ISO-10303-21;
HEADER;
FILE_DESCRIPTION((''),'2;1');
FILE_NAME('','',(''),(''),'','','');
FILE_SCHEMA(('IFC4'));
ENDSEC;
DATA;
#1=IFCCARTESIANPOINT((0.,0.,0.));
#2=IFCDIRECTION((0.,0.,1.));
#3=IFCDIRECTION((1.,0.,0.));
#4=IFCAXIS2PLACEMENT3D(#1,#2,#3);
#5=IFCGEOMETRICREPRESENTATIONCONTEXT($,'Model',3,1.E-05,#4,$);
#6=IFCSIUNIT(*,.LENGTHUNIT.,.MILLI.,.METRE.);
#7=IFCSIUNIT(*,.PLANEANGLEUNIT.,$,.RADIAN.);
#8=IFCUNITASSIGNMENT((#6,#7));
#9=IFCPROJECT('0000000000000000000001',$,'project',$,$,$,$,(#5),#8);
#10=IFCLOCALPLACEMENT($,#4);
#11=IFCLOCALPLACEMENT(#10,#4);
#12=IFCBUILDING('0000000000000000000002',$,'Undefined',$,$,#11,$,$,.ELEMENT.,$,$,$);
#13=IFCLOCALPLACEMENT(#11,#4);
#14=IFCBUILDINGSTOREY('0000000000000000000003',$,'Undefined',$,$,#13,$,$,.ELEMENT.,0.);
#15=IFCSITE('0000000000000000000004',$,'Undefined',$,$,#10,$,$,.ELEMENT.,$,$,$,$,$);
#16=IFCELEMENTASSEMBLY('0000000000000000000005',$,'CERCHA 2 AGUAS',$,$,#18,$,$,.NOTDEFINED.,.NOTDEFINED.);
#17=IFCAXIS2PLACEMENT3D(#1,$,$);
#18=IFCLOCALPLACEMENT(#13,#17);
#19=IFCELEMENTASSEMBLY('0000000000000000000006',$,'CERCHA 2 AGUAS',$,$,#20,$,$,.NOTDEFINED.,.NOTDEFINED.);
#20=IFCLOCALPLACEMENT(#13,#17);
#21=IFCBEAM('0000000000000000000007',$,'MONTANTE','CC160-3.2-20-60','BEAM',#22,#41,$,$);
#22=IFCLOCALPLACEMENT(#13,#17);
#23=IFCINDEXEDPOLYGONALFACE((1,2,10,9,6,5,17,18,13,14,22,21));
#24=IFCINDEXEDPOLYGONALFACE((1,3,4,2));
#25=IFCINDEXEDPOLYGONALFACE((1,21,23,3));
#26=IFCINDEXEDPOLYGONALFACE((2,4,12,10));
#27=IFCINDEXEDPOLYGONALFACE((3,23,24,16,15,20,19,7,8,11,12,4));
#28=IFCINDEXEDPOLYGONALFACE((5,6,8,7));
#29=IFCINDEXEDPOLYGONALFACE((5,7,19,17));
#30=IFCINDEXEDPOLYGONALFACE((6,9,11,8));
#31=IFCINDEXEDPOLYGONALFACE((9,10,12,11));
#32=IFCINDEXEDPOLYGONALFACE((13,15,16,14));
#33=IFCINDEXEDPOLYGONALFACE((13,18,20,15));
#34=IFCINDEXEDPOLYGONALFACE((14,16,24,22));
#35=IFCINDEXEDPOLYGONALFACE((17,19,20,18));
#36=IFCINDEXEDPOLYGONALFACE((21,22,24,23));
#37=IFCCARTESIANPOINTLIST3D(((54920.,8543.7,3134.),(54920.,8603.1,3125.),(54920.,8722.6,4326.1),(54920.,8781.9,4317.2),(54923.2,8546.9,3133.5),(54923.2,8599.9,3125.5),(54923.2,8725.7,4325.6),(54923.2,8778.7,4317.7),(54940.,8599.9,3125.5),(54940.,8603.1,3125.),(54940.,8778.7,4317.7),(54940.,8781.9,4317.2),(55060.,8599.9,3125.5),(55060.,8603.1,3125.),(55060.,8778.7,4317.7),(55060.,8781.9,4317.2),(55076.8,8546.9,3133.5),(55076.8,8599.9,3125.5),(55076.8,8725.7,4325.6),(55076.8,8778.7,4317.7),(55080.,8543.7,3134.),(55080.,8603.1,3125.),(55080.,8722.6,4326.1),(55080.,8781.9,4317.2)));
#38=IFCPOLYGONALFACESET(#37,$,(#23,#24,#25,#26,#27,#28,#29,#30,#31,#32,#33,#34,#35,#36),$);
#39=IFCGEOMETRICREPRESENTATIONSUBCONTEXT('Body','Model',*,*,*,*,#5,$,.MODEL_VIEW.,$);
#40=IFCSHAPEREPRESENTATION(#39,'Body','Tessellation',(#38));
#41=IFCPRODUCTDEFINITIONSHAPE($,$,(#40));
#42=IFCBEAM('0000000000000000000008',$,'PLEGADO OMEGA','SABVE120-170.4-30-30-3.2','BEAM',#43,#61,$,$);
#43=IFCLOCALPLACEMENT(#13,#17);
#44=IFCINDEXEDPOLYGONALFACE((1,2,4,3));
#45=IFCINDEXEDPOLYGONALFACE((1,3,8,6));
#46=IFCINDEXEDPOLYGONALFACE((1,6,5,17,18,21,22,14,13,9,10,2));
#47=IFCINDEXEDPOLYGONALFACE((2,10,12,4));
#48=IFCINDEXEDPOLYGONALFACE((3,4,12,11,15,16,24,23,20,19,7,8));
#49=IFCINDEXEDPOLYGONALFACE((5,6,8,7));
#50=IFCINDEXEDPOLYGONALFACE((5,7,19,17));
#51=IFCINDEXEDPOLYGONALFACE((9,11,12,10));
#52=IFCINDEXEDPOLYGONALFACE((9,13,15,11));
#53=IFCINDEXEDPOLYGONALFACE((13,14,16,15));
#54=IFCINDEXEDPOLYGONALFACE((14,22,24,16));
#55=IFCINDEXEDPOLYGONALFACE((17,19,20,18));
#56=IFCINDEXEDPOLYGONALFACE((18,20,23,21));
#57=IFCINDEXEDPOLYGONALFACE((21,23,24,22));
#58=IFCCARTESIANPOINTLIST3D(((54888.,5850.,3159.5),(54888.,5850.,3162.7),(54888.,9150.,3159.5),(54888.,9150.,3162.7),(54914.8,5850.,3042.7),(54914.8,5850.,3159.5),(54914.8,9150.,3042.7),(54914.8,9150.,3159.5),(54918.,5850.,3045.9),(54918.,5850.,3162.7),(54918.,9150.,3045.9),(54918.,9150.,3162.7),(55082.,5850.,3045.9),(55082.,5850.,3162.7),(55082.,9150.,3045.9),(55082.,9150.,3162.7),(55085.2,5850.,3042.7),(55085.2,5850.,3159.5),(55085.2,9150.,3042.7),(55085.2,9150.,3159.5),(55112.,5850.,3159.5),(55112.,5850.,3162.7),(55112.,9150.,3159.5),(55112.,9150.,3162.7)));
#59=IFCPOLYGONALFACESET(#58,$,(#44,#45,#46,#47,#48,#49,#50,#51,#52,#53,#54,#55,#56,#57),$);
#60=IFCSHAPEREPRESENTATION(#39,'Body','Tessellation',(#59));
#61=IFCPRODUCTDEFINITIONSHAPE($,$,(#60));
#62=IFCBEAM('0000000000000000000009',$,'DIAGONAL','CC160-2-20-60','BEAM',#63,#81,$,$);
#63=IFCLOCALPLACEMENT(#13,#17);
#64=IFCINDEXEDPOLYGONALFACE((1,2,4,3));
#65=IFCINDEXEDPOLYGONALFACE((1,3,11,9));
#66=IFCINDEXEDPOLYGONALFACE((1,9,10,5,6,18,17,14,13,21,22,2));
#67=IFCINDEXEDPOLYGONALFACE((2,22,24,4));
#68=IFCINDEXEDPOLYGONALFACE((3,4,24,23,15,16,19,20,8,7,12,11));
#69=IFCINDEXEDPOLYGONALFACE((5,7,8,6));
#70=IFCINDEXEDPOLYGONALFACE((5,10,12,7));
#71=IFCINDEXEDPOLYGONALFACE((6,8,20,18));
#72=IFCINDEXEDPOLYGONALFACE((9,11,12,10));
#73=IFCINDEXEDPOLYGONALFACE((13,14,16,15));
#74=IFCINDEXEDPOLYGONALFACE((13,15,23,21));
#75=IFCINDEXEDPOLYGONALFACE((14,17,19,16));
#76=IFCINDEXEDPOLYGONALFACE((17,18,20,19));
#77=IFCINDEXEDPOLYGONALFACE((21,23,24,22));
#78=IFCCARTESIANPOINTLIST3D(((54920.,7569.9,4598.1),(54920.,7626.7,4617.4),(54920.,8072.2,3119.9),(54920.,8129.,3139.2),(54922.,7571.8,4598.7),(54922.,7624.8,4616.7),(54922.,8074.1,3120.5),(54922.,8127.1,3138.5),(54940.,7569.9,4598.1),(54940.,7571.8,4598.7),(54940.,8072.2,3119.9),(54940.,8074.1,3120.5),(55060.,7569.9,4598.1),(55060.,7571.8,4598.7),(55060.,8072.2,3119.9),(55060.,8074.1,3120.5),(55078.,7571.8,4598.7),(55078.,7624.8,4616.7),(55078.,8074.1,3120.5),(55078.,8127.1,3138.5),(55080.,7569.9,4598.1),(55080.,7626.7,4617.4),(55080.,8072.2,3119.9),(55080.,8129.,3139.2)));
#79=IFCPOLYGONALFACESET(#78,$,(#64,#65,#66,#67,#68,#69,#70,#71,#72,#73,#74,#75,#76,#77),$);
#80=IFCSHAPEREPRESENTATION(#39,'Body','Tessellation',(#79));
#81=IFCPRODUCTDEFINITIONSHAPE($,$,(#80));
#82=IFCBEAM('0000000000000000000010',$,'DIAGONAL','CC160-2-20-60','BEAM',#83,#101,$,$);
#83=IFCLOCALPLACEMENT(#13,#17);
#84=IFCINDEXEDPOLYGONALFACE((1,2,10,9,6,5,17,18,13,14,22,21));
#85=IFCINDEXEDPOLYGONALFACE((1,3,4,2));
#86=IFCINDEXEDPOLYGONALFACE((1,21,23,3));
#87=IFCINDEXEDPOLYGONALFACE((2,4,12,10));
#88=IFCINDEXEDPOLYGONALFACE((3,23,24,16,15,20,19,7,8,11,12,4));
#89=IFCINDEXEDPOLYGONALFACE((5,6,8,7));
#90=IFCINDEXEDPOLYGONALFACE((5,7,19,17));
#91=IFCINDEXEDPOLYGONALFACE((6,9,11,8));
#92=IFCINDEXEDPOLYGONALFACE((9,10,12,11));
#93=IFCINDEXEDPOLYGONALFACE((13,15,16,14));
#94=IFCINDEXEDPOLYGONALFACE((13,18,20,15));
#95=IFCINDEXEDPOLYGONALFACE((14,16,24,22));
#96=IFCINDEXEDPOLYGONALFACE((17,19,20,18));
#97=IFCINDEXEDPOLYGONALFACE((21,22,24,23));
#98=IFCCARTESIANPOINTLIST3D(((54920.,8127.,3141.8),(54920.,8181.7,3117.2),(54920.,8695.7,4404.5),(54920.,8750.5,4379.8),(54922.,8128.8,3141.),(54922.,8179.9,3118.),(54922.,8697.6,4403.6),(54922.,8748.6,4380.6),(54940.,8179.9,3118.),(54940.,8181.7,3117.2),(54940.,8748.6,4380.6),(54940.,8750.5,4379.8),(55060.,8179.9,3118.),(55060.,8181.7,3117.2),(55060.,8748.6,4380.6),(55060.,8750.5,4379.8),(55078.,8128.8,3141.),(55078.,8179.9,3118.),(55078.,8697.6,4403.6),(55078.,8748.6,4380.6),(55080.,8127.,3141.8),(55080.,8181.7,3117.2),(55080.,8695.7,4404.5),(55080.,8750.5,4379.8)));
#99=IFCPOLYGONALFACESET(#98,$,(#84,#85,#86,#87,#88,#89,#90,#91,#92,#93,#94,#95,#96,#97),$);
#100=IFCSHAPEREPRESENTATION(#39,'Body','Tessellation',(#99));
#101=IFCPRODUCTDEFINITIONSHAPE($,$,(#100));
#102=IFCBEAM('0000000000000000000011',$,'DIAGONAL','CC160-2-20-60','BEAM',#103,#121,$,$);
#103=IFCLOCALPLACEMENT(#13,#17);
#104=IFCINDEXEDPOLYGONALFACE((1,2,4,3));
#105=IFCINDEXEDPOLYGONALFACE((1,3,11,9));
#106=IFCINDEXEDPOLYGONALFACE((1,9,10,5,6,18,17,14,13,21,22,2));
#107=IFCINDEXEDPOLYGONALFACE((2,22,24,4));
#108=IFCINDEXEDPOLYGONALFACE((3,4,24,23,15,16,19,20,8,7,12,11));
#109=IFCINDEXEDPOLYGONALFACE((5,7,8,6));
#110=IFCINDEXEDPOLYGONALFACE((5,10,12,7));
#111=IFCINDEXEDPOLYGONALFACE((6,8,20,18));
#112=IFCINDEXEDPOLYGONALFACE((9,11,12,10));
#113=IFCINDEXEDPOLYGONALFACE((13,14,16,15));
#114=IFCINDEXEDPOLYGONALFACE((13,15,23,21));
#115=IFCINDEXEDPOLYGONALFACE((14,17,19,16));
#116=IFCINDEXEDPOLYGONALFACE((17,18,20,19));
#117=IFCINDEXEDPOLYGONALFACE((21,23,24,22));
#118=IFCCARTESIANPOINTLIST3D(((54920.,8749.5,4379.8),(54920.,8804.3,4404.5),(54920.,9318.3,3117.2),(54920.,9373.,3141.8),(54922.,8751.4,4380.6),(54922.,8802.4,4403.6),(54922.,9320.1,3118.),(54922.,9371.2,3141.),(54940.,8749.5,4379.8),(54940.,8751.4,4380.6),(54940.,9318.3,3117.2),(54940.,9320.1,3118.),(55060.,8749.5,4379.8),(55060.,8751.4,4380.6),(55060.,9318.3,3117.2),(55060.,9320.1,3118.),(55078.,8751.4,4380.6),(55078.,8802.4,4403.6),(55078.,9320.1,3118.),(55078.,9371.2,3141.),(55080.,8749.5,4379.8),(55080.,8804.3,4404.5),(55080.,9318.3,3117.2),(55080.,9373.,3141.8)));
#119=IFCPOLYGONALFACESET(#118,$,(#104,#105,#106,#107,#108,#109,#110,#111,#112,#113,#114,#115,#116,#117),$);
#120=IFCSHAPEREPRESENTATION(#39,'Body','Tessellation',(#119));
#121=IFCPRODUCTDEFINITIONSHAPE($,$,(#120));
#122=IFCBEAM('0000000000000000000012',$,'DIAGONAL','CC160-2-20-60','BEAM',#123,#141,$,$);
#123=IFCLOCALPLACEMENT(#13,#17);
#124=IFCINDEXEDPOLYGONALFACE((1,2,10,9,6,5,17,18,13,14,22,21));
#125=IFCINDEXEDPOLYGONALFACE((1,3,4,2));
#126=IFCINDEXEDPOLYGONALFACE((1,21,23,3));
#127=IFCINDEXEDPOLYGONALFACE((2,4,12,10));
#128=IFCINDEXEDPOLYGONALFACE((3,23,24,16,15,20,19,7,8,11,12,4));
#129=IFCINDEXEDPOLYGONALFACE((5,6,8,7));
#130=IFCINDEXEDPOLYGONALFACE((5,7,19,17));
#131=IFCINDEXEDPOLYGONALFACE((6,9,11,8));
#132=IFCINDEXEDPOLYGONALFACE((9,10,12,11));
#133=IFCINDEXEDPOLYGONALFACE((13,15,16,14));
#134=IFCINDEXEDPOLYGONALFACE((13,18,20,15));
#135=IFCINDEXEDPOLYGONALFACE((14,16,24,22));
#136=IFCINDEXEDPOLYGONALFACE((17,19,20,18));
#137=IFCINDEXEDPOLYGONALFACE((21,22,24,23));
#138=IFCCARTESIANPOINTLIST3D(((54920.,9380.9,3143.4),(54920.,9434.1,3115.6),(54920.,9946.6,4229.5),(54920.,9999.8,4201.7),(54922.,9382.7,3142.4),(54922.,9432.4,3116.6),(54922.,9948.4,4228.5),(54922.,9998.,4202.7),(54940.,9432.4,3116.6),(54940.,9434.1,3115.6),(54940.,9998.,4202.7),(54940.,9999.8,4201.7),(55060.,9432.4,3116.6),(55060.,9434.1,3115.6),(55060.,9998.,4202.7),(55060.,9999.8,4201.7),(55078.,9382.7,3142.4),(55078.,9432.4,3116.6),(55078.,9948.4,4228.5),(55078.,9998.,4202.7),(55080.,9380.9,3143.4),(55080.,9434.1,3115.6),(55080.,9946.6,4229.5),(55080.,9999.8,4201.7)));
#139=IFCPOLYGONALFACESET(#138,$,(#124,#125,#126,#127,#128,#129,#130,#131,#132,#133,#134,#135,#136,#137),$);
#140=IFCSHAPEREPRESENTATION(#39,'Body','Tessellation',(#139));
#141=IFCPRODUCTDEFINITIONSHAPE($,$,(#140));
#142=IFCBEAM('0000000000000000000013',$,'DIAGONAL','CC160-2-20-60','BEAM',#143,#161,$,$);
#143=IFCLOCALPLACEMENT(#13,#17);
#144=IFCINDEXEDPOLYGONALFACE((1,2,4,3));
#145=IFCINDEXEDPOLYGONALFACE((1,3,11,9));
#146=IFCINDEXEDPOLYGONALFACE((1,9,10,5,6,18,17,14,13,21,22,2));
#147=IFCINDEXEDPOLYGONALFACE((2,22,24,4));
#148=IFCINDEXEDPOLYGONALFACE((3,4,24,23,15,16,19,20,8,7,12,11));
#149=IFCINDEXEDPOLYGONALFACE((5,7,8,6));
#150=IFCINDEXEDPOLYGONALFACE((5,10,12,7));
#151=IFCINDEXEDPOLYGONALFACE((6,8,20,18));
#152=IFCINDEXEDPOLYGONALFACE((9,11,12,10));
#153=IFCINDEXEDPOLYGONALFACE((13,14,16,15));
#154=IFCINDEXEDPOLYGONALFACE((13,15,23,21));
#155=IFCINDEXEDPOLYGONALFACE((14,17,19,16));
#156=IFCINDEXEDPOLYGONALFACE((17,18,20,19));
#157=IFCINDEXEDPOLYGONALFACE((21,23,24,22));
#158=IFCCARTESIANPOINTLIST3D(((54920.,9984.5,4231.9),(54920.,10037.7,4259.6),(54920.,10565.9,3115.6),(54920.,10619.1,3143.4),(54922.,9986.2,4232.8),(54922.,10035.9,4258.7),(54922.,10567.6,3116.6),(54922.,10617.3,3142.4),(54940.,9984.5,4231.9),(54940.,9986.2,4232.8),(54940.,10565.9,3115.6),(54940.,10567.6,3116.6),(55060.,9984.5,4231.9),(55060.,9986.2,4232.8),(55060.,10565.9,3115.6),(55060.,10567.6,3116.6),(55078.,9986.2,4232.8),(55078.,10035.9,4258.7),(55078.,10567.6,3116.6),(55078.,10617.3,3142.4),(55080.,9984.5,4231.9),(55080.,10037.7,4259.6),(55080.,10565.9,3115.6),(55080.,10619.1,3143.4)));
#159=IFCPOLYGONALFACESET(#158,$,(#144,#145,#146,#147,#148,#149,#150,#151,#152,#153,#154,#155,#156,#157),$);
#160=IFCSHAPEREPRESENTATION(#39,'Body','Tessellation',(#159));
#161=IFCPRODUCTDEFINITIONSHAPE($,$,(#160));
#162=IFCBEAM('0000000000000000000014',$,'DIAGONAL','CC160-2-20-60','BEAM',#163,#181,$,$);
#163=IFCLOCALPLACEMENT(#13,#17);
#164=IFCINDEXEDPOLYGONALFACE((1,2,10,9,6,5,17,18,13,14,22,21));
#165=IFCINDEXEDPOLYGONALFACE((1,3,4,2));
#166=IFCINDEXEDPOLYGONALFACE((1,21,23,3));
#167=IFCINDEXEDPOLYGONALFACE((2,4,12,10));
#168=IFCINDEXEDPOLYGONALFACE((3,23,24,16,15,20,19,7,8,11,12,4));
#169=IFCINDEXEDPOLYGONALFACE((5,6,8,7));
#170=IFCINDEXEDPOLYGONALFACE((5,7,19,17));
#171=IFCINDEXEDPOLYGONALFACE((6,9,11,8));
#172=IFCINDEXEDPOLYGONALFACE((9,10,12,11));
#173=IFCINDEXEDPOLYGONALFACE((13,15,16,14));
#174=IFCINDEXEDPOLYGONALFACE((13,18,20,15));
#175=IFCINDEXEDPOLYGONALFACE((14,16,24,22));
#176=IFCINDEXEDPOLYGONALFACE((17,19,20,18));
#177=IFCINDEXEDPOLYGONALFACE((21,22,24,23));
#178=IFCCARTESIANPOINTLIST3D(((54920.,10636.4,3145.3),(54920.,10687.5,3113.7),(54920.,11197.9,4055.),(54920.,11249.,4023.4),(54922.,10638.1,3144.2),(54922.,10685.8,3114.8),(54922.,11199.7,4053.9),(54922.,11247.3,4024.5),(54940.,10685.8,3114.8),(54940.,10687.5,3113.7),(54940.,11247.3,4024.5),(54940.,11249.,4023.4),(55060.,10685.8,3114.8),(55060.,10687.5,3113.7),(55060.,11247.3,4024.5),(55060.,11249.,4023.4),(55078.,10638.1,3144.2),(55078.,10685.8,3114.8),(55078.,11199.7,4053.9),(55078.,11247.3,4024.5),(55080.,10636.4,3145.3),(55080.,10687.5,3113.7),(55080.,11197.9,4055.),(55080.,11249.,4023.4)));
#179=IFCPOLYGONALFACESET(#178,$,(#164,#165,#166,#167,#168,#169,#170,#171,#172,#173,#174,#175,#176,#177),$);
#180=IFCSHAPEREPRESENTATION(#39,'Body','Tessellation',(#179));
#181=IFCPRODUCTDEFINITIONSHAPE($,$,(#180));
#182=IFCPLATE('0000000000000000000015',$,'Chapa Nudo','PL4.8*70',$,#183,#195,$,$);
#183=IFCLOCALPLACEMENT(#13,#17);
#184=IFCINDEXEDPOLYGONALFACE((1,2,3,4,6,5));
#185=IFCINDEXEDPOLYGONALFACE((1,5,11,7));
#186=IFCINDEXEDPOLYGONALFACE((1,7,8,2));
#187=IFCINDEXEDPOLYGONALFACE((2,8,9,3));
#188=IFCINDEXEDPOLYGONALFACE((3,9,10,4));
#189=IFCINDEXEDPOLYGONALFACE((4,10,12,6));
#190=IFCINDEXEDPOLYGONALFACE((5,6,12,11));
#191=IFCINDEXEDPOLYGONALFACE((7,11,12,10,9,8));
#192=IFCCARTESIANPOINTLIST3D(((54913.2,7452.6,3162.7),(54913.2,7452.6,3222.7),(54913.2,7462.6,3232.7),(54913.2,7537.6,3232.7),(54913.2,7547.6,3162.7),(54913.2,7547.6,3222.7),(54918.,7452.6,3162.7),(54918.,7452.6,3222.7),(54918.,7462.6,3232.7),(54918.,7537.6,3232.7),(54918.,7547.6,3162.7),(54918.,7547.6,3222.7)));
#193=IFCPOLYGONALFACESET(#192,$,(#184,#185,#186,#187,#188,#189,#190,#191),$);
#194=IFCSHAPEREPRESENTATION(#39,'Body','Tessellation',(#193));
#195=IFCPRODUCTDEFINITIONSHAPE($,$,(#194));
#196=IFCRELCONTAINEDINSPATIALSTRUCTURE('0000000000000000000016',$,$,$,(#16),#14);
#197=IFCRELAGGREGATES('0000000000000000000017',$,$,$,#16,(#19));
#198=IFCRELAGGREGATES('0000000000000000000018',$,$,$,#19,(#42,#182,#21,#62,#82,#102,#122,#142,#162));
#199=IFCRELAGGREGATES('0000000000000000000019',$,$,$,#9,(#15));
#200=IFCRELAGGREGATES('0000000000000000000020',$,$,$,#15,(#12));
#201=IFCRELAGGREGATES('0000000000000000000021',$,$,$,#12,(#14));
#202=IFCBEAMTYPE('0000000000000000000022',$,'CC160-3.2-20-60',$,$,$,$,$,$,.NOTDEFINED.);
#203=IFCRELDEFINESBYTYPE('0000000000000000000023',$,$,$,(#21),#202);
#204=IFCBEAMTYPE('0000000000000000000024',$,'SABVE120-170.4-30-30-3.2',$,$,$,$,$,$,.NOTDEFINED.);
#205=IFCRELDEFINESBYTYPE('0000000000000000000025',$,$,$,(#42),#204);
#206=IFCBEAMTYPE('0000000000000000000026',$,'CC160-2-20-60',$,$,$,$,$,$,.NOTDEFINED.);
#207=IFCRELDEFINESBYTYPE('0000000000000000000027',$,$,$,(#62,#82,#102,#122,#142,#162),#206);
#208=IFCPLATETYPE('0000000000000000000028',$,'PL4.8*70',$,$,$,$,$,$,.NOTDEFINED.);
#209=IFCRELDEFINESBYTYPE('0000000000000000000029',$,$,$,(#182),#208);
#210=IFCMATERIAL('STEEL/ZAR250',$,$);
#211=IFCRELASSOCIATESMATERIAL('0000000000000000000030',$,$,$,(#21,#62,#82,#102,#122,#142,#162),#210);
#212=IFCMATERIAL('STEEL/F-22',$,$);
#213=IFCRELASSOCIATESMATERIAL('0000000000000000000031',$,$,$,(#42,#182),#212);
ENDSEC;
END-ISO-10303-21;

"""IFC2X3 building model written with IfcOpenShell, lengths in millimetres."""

from ifc_helpers import new_model, si_unit, frame, origin_with_axes, origin_2d_with_axis, place, context, subcontext, project, spatial, polyline, c_section, outline, extrude, material, type_object, element, aggregate, save


model = new_model("IFC2X3")

# Units and contexts
model_context = context("Model", 3, precision=1e-05, world=origin_with_axes())
body_context = subcontext(model_context, "Body", "Model", "MODEL_VIEW")
ifc_project = project(units=[si_unit("LENGTHUNIT", "METRE", prefix="MILLI"), si_unit("PLANEANGLEUNIT", "RADIAN")], contexts=[model_context])

# Site, building, storey
site_placement = place(None, origin_with_axes())
site = spatial("IfcSite", under=ifc_project, at=site_placement, Name="Undefined", CompositionType="ELEMENT")
building_placement = place(site_placement, origin_with_axes())
building = spatial("IfcBuilding", under=site, at=building_placement, Name="Undefined", CompositionType="ELEMENT")
storey_placement = place(building_placement, origin_with_axes())
storey = spatial("IfcBuildingStorey", under=building, at=storey_placement, Name="Undefined", CompositionType="ELEMENT", Elevation=0.0)

# Element assemblies, beams, plate
assembly_1_placement = place(storey_placement, origin_with_axes())
assembly_1 = element("IfcElementAssembly", 1, at=assembly_1_placement, inside=storey, Name="CERCHA 2 AGUAS", AssemblyPlace="NOTDEFINED", PredefinedType="NOTDEFINED")
assembly_2_placement = place(assembly_1_placement, origin_with_axes())
assembly_2 = element("IfcElementAssembly", 2, at=assembly_2_placement, Name="CERCHA 2 AGUAS", AssemblyPlace="NOTDEFINED", PredefinedType="NOTDEFINED")
aggregate(assembly_1, [assembly_2])
ifc_material_1 = material(Name="STEEL/ZAR250")
beam_type_1 = type_object("IfcBeamType", Name="CC160-3.2-20-60", PredefinedType="NOTDEFINED")
beam_1_placement = place(assembly_2_placement, frame((55000.0, 8752.2, 4321.6), z_axis=(-1.0, 0.0, 0.0), x_axis=(0.0, -0.14834, -0.988936)))
beam_1 = element("IfcBeam", 3, at=beam_1_placement, type_object=beam_type_1, material=ifc_material_1, Name="MONTANTE", Description="CC160-3.2-20-60", ObjectType="BEAM", context=body_context, shape_type="SweptSolid", body=[
    extrude(c_section(Depth=160.0, Width=60.0, WallThickness=3.2, Girth=20.0, at=origin_2d_with_axis()), frame((1205.5, 0.0, 0.0), z_axis=(-1.0, 0.0, 0.0), x_axis=(0.0, -1.0, 0.0)), (0.0, 0.0, 1.0), 1205.5),
])
ifc_material_2 = material(Name="STEEL/F-22")
beam_type_2 = type_object("IfcBeamType", Name="SABVE120-170.4-30-30-3.2", PredefinedType="NOTDEFINED")
beam_2_placement = place(assembly_2_placement, frame((55000.0, 9150.0, 3102.7), z_axis=(0.0, 0.0, 1.0), x_axis=(0.0, -1.0, 0.0)))
beam_2 = element("IfcBeam", 4, at=beam_2_placement, type_object=beam_type_2, material=ifc_material_2, Name="PLEGADO OMEGA", Description="SABVE120-170.4-30-30-3.2", ObjectType="BEAM", context=body_context, shape_type="SweptSolid", body=[
    extrude(outline(polyline([(82.0, 60.0), (112.0, 60.0), (112.0, 56.8), (85.2, 56.8), (85.2, -60.0), (-85.2, -60.0), (-85.2, 56.8), (-112.0, 56.8), (-112.0, 60.0), (-82.0, 60.0), (-82.0, -56.8), (82.0, -56.8), (82.0, 60.0)])), frame((3300.0, 0.0, 0.0), z_axis=(-1.0, 0.0, 0.0), x_axis=(0.0, -1.0, 0.0)), (0.0, 0.0, 1.0), 3300.0),
])
beam_type_3 = type_object("IfcBeamType", Name="CC160-2-20-60", PredefinedType="NOTDEFINED")
beam_3_placement = place(assembly_2_placement, frame((55000.0, 8100.6, 3129.5), z_axis=(-1.0, 0.0, 0.0), x_axis=(0.0, -0.321737, 0.946829)))
beam_3 = element("IfcBeam", 5, at=beam_3_placement, type_object=beam_type_3, material=ifc_material_1, Name="DIAGONAL", Description="CC160-2-20-60", ObjectType="BEAM", context=body_context, shape_type="SweptSolid", body=[
    extrude(c_section(Depth=160.0, Width=60.0, WallThickness=2.0, Girth=20.0, at=origin_2d_with_axis()), frame((1561.2, 0.0, 0.0), z_axis=(-1.0, 0.0, 0.0), x_axis=(0.0, -1.0, 0.0)), (0.0, 0.0, 1.0), 1561.2),
])
beam_4_placement = place(assembly_2_placement, frame((55000.0, 8723.1, 4392.1), z_axis=(-1.0, 0.0, 0.0), x_axis=(0.0, -0.410706, -0.911768)))
beam_4 = element("IfcBeam", 6, at=beam_4_placement, type_object=beam_type_3, material=ifc_material_1, Name="DIAGONAL", Description="CC160-2-20-60", ObjectType="BEAM", context=body_context, shape_type="SweptSolid", body=[
    extrude(c_section(Depth=160.0, Width=60.0, WallThickness=2.0, Girth=20.0, at=origin_2d_with_axis()), frame((1384.8, 0.0, 0.0), z_axis=(-1.0, 0.0, 0.0), x_axis=(0.0, -1.0, 0.0)), (0.0, 0.0, 1.0), 1384.8),
])
beam_5_placement = place(assembly_2_placement, frame((55000.0, 9345.7, 3129.5), z_axis=(-1.0, 0.0, 0.0), x_axis=(0.0, -0.410706, 0.911768)))
beam_5 = element("IfcBeam", 7, at=beam_5_placement, type_object=beam_type_3, material=ifc_material_1, Name="DIAGONAL", Description="CC160-2-20-60", ObjectType="BEAM", context=body_context, shape_type="SweptSolid", body=[
    extrude(c_section(Depth=160.0, Width=60.0, WallThickness=2.0, Girth=20.0, at=origin_2d_with_axis()), frame((1384.8, 0.0, 0.0), z_axis=(-1.0, 0.0, 0.0), x_axis=(0.0, -1.0, 0.0)), (0.0, 0.0, 1.0), 1384.8),
])
beam_6_placement = place(assembly_2_placement, frame((55000.0, 9973.2, 4215.6), z_axis=(-1.0, 0.0, 0.0), x_axis=(0.0, -0.461934, -0.886914)))
beam_6 = element("IfcBeam", 8, at=beam_6_placement, type_object=beam_type_3, material=ifc_material_1, Name="DIAGONAL", Description="CC160-2-20-60", ObjectType="BEAM", context=body_context, shape_type="SweptSolid", body=[
    extrude(c_section(Depth=160.0, Width=60.0, WallThickness=2.0, Girth=20.0, at=origin_2d_with_axis()), frame((1224.6, 0.0, 0.0), z_axis=(-1.0, 0.0, 0.0), x_axis=(0.0, -1.0, 0.0)), (0.0, 0.0, 1.0), 1224.6),
])
beam_7_placement = place(assembly_2_placement, frame((55000.0, 10592.5, 3129.5), z_axis=(-1.0, 0.0, 0.0), x_axis=(0.0, -0.461934, 0.886914)))
beam_7 = element("IfcBeam", 9, at=beam_7_placement, type_object=beam_type_3, material=ifc_material_1, Name="DIAGONAL", Description="CC160-2-20-60", ObjectType="BEAM", context=body_context, shape_type="SweptSolid", body=[
    extrude(c_section(Depth=160.0, Width=60.0, WallThickness=2.0, Girth=20.0, at=origin_2d_with_axis()), frame((1258.6, 0.0, 0.0), z_axis=(-1.0, 0.0, 0.0), x_axis=(0.0, -1.0, 0.0)), (0.0, 0.0, 1.0), 1258.6),
])
beam_8_placement = place(assembly_2_placement, frame((55000.0, 11223.5, 4039.2), z_axis=(-1.0, 0.0, 0.0), x_axis=(0.0, -0.52527, -0.850936)))
beam_8 = element("IfcBeam", 10, at=beam_8_placement, type_object=beam_type_3, material=ifc_material_1, Name="DIAGONAL", Description="CC160-2-20-60", ObjectType="BEAM", context=body_context, shape_type="SweptSolid", body=[
    extrude(c_section(Depth=160.0, Width=60.0, WallThickness=2.0, Girth=20.0, at=origin_2d_with_axis()), frame((1069.0, 0.0, 0.0), z_axis=(-1.0, 0.0, 0.0), x_axis=(0.0, -1.0, 0.0)), (0.0, 0.0, 1.0), 1069.0),
])
plate_type_1 = type_object("IfcPlateType", Name="PL4.8*70", PredefinedType="NOTDEFINED")
plate_1_placement = place(assembly_2_placement, frame((54915.6, 7452.6, 3232.7), z_axis=(1.0, 0.0, 0.0), x_axis=(0.0, 0.0, -1.0)))
plate_1 = element("IfcPlate", 11, at=plate_1_placement, type_object=plate_type_1, material=ifc_material_2, Name="Chapa Nudo", Description="PL4.8*70", context=body_context, shape_type="SweptSolid", body=[
    extrude(outline(polyline([(0.0, 10.0), (10.0, 0.0), (70.0, 0.0), (70.0, 95.0), (10.0, 95.0), (0.0, 85.0), (0.0, 10.0)])), frame((0.0, 0.0, -2.4), z_axis=(0.0, 0.0, 1.0), x_axis=(1.0, 0.0, 0.0)), (0.0, 0.0, 1.0), 4.8),
])

aggregate(assembly_2, [beam_2, plate_1, beam_1, beam_3, beam_4, beam_5, beam_6, beam_7, beam_8])

save(model, "model.ifc")
